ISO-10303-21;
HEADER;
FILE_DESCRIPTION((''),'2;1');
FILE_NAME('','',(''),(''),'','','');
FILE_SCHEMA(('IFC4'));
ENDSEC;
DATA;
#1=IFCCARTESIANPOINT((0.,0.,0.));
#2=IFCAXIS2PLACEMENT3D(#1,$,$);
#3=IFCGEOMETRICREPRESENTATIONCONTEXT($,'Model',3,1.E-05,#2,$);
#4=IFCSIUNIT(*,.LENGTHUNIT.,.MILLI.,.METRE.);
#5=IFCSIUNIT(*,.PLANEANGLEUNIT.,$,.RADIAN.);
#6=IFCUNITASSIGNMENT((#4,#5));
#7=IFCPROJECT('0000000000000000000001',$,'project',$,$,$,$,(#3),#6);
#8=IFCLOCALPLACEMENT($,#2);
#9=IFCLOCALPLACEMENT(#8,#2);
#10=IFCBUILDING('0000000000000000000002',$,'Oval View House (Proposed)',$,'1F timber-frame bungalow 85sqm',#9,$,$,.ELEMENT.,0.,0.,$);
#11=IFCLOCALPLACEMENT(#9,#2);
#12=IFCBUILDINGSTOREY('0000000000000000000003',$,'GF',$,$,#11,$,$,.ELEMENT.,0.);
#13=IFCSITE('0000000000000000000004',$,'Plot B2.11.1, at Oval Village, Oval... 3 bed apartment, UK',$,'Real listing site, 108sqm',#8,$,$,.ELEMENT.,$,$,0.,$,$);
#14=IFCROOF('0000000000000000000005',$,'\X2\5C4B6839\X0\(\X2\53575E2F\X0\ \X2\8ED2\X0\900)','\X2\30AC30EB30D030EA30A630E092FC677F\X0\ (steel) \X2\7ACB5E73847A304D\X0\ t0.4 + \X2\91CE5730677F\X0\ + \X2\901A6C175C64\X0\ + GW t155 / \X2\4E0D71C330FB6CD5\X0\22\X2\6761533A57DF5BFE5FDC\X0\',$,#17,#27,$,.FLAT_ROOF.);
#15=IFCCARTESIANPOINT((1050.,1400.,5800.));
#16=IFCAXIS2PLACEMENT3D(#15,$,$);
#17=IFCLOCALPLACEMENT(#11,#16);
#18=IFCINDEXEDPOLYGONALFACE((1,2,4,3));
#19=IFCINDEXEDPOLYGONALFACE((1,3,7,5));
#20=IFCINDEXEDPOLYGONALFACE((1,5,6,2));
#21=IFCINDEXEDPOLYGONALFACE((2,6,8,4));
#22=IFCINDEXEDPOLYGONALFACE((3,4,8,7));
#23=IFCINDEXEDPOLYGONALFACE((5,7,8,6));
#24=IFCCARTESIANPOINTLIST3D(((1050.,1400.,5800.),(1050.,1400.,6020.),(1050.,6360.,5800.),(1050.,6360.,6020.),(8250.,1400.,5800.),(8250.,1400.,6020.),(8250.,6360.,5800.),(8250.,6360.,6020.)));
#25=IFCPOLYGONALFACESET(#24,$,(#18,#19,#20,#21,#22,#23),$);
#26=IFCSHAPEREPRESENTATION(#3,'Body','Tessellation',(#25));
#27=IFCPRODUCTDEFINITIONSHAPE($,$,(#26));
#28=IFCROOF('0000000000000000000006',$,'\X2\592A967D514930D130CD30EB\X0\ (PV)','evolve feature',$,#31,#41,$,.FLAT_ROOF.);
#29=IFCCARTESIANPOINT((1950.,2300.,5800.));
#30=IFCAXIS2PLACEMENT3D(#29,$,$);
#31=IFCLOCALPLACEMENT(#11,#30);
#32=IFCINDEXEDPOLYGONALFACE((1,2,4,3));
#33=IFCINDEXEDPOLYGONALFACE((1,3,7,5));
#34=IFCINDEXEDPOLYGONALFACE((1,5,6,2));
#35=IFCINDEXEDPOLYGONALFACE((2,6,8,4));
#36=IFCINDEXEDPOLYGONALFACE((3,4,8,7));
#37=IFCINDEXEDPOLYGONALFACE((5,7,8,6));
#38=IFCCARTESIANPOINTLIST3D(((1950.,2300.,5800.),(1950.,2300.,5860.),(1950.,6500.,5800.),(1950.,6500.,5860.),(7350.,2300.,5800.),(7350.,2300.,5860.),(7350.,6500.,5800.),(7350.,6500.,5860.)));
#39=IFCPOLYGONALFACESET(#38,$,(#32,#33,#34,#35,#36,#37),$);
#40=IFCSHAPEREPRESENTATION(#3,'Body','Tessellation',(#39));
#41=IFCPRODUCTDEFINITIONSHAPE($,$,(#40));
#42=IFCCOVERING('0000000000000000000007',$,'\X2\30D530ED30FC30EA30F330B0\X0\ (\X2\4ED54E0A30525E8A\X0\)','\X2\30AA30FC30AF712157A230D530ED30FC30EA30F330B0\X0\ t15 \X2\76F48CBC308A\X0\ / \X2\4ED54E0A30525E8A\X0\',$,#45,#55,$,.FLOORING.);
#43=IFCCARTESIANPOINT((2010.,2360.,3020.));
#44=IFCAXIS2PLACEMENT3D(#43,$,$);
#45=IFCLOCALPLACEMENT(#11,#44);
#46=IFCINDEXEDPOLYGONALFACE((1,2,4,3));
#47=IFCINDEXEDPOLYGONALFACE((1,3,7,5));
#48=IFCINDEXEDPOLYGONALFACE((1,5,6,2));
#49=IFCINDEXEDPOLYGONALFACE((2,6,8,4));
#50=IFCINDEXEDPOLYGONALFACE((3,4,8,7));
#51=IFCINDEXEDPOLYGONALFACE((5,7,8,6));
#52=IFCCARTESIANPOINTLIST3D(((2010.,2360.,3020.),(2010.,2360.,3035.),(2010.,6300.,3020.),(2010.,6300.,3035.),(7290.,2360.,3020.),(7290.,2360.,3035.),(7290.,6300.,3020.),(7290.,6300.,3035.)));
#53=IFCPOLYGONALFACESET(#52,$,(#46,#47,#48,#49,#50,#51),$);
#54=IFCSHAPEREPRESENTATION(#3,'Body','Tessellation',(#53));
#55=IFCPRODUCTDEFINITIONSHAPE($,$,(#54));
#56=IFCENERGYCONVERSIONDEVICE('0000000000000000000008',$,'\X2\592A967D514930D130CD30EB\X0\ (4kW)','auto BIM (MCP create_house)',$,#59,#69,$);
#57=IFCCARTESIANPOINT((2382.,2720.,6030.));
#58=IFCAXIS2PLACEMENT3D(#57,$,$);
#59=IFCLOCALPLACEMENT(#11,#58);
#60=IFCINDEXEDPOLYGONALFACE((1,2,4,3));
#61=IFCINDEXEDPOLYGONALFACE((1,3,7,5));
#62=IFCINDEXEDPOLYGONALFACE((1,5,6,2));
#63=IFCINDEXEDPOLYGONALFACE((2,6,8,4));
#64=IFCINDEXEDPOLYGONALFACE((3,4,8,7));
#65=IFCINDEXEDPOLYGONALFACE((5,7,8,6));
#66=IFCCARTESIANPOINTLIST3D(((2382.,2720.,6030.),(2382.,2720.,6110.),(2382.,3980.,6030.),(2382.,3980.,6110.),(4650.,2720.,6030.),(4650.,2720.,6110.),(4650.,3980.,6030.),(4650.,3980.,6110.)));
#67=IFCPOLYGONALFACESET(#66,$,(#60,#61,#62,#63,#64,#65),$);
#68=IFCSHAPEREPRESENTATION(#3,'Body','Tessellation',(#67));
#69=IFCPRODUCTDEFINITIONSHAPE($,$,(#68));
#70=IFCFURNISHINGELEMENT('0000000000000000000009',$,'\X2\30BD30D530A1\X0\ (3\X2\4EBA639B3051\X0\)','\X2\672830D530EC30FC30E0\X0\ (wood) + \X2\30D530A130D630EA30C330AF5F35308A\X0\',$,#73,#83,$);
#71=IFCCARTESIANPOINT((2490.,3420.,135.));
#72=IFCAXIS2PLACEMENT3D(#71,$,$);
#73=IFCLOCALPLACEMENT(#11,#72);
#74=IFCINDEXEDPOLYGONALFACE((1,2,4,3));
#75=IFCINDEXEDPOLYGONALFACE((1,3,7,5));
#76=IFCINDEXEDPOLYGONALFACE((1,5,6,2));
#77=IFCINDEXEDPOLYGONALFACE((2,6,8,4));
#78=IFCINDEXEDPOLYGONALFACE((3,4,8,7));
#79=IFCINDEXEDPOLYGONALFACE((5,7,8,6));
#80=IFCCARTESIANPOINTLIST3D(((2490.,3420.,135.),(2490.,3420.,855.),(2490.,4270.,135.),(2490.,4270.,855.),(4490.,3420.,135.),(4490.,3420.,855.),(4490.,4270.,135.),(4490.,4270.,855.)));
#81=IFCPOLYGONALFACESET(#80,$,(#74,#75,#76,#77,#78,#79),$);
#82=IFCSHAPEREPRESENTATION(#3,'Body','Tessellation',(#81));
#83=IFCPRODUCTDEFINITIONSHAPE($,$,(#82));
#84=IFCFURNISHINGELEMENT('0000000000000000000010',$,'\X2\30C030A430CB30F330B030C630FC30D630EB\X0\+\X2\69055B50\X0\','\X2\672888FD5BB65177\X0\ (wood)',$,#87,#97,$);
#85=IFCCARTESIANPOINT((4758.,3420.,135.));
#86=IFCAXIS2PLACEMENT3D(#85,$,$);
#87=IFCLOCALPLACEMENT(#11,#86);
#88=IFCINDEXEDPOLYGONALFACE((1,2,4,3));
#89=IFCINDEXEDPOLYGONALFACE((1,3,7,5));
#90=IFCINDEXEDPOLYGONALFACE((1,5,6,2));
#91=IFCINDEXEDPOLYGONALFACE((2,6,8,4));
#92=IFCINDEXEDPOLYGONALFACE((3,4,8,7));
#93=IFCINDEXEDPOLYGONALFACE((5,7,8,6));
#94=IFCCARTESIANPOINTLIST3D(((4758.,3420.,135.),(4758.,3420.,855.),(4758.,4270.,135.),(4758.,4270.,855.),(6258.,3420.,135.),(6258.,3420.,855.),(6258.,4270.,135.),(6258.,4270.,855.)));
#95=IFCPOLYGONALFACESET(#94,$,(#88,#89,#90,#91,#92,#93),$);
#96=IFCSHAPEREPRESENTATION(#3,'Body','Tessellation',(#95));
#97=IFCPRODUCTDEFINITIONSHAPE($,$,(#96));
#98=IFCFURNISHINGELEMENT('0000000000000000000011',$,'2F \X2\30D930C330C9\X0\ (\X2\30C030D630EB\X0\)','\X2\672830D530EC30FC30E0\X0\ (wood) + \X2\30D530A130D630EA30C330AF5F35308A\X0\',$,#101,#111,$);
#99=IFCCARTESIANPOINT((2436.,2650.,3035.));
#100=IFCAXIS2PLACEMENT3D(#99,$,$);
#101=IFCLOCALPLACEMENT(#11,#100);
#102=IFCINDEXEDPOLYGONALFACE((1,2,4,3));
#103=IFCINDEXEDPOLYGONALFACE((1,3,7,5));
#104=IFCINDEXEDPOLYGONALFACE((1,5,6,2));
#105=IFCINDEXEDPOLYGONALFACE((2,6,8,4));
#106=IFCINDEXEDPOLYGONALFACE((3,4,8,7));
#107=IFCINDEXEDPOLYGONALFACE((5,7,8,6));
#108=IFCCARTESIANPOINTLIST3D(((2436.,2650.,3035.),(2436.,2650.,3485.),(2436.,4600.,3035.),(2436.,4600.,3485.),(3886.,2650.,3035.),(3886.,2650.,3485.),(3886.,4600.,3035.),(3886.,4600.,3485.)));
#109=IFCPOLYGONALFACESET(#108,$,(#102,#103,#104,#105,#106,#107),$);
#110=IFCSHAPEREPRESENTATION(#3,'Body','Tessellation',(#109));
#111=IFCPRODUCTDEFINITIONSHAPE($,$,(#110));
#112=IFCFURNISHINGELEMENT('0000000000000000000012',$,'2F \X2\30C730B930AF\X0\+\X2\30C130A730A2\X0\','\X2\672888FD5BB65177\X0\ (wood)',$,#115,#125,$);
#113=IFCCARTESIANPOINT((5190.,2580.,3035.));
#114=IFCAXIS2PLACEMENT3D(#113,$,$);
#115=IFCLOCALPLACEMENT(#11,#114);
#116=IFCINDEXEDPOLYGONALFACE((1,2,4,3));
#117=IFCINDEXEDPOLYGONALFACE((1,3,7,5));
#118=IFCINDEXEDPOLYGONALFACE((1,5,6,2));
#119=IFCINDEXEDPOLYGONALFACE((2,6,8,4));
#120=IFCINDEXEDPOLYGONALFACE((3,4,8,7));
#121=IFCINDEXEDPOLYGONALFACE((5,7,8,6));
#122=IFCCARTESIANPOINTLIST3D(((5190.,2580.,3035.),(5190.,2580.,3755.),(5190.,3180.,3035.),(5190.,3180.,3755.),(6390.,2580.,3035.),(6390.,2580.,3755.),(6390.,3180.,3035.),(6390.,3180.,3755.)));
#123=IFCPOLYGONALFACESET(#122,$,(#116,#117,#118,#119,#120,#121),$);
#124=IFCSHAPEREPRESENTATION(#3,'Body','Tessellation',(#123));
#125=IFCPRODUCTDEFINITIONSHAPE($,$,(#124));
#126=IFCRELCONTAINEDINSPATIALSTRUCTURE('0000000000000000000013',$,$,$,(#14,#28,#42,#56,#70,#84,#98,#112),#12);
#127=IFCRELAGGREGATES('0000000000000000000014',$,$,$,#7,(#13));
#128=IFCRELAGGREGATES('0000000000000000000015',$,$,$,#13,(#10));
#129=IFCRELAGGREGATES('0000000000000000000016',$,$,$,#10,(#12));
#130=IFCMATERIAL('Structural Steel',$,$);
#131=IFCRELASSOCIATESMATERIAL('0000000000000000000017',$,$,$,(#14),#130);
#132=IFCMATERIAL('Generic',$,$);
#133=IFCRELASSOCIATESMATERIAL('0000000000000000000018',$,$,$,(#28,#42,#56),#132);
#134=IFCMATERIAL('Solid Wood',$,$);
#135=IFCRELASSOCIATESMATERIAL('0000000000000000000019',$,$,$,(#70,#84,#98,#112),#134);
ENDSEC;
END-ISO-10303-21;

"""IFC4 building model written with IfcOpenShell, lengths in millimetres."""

from ifc_helpers import new_model, si_unit, frame, frame_2d, origin, place, context, project, spatial, rectangle, extrude, material, element, save


model = new_model("IFC4")

# Units and contexts
model_context = context("Model", 3, precision=1e-05, world=origin())
ifc_project = project(units=[si_unit("LENGTHUNIT", "METRE", prefix="MILLI"), si_unit("PLANEANGLEUNIT", "RADIAN")], contexts=[model_context])

# Site, building, storey
site_placement = place(None, origin())
site = spatial("IfcSite", under=ifc_project, at=site_placement, Name="Plot B2.11.1, at Oval Village, Oval... 3 bed apartment, UK", ObjectType="Real listing site, 108sqm", CompositionType="ELEMENT", RefElevation=0.0)
building_placement = place(site_placement, origin())
building = spatial("IfcBuilding", under=site, at=building_placement, Name="Oval View House (Proposed)", ObjectType="1F timber-frame bungalow 85sqm", CompositionType="ELEMENT", ElevationOfRefHeight=0.0, ElevationOfTerrain=0.0)
storey_placement = place(building_placement, origin())
storey = spatial("IfcBuildingStorey", under=building, at=storey_placement, Name="GF", CompositionType="ELEMENT", Elevation=0.0)

# Shared definitions
ifc_material_1 = material(Name="Solid Wood")

# Shared definitions
ifc_material_2 = material(Name="Generic")

# Roofs
ifc_material_3 = material(Name="Structural Steel")
for number, where, name in (
    (1, (1050.0, 1400.0, 5800.0), "屋根(南帯 軒900)"),
):
    element("IfcRoof", number, at=place(storey_placement, frame(where)), inside=storey, material=ifc_material_3, Name=name, Description="ガルバリウム鋼板 (steel) 立平葺き t0.4 + 野地板 + 通気層 + GW t155 / 不燃・法22条区域対応", PredefinedType="FLAT_ROOF", context=model_context, shape_type="SweptSolid", body=[
        extrude(rectangle(XDim=7200.0, YDim=4960.0, at=frame_2d((3600.0, 2480.0))), frame((1050.0, 1400.0, 5800.0)), (0.0, 0.0, 1.0), 220.0),
    ])
roof_placement = place(storey_placement, frame((1950.0, 2300.0, 5800.0)))
element("IfcRoof", 2, at=roof_placement, inside=storey, material=ifc_material_2, Name="太陽光パネル (PV)", Description="evolve feature", PredefinedType="FLAT_ROOF", context=model_context, shape_type="SweptSolid", body=[
    extrude(rectangle(XDim=5400.0, YDim=4200.0, at=frame_2d((2700.0, 2100.0))), frame((1950.0, 2300.0, 5800.0)), (0.0, 0.0, 1.0), 60.0),
])

# Covering
covering_placement = place(storey_placement, frame((2010.0, 2360.0, 3020.0)))
element("IfcCovering", 3, at=covering_placement, inside=storey, material=ifc_material_2, Name="フローリング (仕上げ床)", Description="オーク無垢フローリング t15 直貼り / 仕上げ床", PredefinedType="FLOORING", context=model_context, shape_type="SweptSolid", body=[
    extrude(rectangle(XDim=5280.0, YDim=3940.0, at=frame_2d((2640.0, 1970.0))), frame((2010.0, 2360.0, 3020.0)), (0.0, 0.0, 1.0), 15.0),
])

# Energy conversion device
energy_conversion_device_placement = place(storey_placement, frame((2382.0, 2720.0, 6030.0)))
element("IfcEnergyConversionDevice", 4, at=energy_conversion_device_placement, inside=storey, material=ifc_material_2, Name="太陽光パネル (4kW)", Description="auto BIM (MCP create_house)", context=model_context, shape_type="SweptSolid", body=[
    extrude(rectangle(XDim=2268.0, YDim=1260.0, at=frame_2d((1134.0, 630.0))), frame((2382.0, 2720.0, 6030.0)), (0.0, 0.0, 1.0), 80.0),
])

# Furnishing elements
furnishing_1_placement = place(storey_placement, frame((2490.0, 3420.0, 135.0)))
element("IfcFurnishingElement", 5, at=furnishing_1_placement, inside=storey, material=ifc_material_1, Name="ソファ (3人掛け)", Description="木フレーム (wood) + ファブリック張り", context=model_context, shape_type="SweptSolid", body=[
    extrude(rectangle(XDim=2000.0, YDim=850.0, at=frame_2d((1000.0, 425.0))), frame((2490.0, 3420.0, 135.0)), (0.0, 0.0, 1.0), 720.0),
])
furnishing_2_placement = place(storey_placement, frame((4758.0, 3420.0, 135.0)))
element("IfcFurnishingElement", 6, at=furnishing_2_placement, inside=storey, material=ifc_material_1, Name="ダイニングテーブル+椅子", Description="木製家具 (wood)", context=model_context, shape_type="SweptSolid", body=[
    extrude(rectangle(XDim=1500.0, YDim=850.0, at=frame_2d((750.0, 425.0))), frame((4758.0, 3420.0, 135.0)), (0.0, 0.0, 1.0), 720.0),
])
furnishing_3_placement = place(storey_placement, frame((2436.0, 2650.0, 3035.0)))
element("IfcFurnishingElement", 7, at=furnishing_3_placement, inside=storey, material=ifc_material_1, Name="2F ベッド (ダブル)", Description="木フレーム (wood) + ファブリック張り", context=model_context, shape_type="SweptSolid", body=[
    extrude(rectangle(XDim=1450.0, YDim=1950.0, at=frame_2d((725.0, 975.0))), frame((2436.0, 2650.0, 3035.0)), (0.0, 0.0, 1.0), 450.0),
])
furnishing_4_placement = place(storey_placement, frame((5190.0, 2580.0, 3035.0)))
element("IfcFurnishingElement", 8, at=furnishing_4_placement, inside=storey, material=ifc_material_1, Name="2F デスク+チェア", Description="木製家具 (wood)", context=model_context, shape_type="SweptSolid", body=[
    extrude(rectangle(XDim=1200.0, YDim=600.0, at=frame_2d((600.0, 300.0))), frame((5190.0, 2580.0, 3035.0)), (0.0, 0.0, 1.0), 720.0),
])

save(model, "model.ifc")
